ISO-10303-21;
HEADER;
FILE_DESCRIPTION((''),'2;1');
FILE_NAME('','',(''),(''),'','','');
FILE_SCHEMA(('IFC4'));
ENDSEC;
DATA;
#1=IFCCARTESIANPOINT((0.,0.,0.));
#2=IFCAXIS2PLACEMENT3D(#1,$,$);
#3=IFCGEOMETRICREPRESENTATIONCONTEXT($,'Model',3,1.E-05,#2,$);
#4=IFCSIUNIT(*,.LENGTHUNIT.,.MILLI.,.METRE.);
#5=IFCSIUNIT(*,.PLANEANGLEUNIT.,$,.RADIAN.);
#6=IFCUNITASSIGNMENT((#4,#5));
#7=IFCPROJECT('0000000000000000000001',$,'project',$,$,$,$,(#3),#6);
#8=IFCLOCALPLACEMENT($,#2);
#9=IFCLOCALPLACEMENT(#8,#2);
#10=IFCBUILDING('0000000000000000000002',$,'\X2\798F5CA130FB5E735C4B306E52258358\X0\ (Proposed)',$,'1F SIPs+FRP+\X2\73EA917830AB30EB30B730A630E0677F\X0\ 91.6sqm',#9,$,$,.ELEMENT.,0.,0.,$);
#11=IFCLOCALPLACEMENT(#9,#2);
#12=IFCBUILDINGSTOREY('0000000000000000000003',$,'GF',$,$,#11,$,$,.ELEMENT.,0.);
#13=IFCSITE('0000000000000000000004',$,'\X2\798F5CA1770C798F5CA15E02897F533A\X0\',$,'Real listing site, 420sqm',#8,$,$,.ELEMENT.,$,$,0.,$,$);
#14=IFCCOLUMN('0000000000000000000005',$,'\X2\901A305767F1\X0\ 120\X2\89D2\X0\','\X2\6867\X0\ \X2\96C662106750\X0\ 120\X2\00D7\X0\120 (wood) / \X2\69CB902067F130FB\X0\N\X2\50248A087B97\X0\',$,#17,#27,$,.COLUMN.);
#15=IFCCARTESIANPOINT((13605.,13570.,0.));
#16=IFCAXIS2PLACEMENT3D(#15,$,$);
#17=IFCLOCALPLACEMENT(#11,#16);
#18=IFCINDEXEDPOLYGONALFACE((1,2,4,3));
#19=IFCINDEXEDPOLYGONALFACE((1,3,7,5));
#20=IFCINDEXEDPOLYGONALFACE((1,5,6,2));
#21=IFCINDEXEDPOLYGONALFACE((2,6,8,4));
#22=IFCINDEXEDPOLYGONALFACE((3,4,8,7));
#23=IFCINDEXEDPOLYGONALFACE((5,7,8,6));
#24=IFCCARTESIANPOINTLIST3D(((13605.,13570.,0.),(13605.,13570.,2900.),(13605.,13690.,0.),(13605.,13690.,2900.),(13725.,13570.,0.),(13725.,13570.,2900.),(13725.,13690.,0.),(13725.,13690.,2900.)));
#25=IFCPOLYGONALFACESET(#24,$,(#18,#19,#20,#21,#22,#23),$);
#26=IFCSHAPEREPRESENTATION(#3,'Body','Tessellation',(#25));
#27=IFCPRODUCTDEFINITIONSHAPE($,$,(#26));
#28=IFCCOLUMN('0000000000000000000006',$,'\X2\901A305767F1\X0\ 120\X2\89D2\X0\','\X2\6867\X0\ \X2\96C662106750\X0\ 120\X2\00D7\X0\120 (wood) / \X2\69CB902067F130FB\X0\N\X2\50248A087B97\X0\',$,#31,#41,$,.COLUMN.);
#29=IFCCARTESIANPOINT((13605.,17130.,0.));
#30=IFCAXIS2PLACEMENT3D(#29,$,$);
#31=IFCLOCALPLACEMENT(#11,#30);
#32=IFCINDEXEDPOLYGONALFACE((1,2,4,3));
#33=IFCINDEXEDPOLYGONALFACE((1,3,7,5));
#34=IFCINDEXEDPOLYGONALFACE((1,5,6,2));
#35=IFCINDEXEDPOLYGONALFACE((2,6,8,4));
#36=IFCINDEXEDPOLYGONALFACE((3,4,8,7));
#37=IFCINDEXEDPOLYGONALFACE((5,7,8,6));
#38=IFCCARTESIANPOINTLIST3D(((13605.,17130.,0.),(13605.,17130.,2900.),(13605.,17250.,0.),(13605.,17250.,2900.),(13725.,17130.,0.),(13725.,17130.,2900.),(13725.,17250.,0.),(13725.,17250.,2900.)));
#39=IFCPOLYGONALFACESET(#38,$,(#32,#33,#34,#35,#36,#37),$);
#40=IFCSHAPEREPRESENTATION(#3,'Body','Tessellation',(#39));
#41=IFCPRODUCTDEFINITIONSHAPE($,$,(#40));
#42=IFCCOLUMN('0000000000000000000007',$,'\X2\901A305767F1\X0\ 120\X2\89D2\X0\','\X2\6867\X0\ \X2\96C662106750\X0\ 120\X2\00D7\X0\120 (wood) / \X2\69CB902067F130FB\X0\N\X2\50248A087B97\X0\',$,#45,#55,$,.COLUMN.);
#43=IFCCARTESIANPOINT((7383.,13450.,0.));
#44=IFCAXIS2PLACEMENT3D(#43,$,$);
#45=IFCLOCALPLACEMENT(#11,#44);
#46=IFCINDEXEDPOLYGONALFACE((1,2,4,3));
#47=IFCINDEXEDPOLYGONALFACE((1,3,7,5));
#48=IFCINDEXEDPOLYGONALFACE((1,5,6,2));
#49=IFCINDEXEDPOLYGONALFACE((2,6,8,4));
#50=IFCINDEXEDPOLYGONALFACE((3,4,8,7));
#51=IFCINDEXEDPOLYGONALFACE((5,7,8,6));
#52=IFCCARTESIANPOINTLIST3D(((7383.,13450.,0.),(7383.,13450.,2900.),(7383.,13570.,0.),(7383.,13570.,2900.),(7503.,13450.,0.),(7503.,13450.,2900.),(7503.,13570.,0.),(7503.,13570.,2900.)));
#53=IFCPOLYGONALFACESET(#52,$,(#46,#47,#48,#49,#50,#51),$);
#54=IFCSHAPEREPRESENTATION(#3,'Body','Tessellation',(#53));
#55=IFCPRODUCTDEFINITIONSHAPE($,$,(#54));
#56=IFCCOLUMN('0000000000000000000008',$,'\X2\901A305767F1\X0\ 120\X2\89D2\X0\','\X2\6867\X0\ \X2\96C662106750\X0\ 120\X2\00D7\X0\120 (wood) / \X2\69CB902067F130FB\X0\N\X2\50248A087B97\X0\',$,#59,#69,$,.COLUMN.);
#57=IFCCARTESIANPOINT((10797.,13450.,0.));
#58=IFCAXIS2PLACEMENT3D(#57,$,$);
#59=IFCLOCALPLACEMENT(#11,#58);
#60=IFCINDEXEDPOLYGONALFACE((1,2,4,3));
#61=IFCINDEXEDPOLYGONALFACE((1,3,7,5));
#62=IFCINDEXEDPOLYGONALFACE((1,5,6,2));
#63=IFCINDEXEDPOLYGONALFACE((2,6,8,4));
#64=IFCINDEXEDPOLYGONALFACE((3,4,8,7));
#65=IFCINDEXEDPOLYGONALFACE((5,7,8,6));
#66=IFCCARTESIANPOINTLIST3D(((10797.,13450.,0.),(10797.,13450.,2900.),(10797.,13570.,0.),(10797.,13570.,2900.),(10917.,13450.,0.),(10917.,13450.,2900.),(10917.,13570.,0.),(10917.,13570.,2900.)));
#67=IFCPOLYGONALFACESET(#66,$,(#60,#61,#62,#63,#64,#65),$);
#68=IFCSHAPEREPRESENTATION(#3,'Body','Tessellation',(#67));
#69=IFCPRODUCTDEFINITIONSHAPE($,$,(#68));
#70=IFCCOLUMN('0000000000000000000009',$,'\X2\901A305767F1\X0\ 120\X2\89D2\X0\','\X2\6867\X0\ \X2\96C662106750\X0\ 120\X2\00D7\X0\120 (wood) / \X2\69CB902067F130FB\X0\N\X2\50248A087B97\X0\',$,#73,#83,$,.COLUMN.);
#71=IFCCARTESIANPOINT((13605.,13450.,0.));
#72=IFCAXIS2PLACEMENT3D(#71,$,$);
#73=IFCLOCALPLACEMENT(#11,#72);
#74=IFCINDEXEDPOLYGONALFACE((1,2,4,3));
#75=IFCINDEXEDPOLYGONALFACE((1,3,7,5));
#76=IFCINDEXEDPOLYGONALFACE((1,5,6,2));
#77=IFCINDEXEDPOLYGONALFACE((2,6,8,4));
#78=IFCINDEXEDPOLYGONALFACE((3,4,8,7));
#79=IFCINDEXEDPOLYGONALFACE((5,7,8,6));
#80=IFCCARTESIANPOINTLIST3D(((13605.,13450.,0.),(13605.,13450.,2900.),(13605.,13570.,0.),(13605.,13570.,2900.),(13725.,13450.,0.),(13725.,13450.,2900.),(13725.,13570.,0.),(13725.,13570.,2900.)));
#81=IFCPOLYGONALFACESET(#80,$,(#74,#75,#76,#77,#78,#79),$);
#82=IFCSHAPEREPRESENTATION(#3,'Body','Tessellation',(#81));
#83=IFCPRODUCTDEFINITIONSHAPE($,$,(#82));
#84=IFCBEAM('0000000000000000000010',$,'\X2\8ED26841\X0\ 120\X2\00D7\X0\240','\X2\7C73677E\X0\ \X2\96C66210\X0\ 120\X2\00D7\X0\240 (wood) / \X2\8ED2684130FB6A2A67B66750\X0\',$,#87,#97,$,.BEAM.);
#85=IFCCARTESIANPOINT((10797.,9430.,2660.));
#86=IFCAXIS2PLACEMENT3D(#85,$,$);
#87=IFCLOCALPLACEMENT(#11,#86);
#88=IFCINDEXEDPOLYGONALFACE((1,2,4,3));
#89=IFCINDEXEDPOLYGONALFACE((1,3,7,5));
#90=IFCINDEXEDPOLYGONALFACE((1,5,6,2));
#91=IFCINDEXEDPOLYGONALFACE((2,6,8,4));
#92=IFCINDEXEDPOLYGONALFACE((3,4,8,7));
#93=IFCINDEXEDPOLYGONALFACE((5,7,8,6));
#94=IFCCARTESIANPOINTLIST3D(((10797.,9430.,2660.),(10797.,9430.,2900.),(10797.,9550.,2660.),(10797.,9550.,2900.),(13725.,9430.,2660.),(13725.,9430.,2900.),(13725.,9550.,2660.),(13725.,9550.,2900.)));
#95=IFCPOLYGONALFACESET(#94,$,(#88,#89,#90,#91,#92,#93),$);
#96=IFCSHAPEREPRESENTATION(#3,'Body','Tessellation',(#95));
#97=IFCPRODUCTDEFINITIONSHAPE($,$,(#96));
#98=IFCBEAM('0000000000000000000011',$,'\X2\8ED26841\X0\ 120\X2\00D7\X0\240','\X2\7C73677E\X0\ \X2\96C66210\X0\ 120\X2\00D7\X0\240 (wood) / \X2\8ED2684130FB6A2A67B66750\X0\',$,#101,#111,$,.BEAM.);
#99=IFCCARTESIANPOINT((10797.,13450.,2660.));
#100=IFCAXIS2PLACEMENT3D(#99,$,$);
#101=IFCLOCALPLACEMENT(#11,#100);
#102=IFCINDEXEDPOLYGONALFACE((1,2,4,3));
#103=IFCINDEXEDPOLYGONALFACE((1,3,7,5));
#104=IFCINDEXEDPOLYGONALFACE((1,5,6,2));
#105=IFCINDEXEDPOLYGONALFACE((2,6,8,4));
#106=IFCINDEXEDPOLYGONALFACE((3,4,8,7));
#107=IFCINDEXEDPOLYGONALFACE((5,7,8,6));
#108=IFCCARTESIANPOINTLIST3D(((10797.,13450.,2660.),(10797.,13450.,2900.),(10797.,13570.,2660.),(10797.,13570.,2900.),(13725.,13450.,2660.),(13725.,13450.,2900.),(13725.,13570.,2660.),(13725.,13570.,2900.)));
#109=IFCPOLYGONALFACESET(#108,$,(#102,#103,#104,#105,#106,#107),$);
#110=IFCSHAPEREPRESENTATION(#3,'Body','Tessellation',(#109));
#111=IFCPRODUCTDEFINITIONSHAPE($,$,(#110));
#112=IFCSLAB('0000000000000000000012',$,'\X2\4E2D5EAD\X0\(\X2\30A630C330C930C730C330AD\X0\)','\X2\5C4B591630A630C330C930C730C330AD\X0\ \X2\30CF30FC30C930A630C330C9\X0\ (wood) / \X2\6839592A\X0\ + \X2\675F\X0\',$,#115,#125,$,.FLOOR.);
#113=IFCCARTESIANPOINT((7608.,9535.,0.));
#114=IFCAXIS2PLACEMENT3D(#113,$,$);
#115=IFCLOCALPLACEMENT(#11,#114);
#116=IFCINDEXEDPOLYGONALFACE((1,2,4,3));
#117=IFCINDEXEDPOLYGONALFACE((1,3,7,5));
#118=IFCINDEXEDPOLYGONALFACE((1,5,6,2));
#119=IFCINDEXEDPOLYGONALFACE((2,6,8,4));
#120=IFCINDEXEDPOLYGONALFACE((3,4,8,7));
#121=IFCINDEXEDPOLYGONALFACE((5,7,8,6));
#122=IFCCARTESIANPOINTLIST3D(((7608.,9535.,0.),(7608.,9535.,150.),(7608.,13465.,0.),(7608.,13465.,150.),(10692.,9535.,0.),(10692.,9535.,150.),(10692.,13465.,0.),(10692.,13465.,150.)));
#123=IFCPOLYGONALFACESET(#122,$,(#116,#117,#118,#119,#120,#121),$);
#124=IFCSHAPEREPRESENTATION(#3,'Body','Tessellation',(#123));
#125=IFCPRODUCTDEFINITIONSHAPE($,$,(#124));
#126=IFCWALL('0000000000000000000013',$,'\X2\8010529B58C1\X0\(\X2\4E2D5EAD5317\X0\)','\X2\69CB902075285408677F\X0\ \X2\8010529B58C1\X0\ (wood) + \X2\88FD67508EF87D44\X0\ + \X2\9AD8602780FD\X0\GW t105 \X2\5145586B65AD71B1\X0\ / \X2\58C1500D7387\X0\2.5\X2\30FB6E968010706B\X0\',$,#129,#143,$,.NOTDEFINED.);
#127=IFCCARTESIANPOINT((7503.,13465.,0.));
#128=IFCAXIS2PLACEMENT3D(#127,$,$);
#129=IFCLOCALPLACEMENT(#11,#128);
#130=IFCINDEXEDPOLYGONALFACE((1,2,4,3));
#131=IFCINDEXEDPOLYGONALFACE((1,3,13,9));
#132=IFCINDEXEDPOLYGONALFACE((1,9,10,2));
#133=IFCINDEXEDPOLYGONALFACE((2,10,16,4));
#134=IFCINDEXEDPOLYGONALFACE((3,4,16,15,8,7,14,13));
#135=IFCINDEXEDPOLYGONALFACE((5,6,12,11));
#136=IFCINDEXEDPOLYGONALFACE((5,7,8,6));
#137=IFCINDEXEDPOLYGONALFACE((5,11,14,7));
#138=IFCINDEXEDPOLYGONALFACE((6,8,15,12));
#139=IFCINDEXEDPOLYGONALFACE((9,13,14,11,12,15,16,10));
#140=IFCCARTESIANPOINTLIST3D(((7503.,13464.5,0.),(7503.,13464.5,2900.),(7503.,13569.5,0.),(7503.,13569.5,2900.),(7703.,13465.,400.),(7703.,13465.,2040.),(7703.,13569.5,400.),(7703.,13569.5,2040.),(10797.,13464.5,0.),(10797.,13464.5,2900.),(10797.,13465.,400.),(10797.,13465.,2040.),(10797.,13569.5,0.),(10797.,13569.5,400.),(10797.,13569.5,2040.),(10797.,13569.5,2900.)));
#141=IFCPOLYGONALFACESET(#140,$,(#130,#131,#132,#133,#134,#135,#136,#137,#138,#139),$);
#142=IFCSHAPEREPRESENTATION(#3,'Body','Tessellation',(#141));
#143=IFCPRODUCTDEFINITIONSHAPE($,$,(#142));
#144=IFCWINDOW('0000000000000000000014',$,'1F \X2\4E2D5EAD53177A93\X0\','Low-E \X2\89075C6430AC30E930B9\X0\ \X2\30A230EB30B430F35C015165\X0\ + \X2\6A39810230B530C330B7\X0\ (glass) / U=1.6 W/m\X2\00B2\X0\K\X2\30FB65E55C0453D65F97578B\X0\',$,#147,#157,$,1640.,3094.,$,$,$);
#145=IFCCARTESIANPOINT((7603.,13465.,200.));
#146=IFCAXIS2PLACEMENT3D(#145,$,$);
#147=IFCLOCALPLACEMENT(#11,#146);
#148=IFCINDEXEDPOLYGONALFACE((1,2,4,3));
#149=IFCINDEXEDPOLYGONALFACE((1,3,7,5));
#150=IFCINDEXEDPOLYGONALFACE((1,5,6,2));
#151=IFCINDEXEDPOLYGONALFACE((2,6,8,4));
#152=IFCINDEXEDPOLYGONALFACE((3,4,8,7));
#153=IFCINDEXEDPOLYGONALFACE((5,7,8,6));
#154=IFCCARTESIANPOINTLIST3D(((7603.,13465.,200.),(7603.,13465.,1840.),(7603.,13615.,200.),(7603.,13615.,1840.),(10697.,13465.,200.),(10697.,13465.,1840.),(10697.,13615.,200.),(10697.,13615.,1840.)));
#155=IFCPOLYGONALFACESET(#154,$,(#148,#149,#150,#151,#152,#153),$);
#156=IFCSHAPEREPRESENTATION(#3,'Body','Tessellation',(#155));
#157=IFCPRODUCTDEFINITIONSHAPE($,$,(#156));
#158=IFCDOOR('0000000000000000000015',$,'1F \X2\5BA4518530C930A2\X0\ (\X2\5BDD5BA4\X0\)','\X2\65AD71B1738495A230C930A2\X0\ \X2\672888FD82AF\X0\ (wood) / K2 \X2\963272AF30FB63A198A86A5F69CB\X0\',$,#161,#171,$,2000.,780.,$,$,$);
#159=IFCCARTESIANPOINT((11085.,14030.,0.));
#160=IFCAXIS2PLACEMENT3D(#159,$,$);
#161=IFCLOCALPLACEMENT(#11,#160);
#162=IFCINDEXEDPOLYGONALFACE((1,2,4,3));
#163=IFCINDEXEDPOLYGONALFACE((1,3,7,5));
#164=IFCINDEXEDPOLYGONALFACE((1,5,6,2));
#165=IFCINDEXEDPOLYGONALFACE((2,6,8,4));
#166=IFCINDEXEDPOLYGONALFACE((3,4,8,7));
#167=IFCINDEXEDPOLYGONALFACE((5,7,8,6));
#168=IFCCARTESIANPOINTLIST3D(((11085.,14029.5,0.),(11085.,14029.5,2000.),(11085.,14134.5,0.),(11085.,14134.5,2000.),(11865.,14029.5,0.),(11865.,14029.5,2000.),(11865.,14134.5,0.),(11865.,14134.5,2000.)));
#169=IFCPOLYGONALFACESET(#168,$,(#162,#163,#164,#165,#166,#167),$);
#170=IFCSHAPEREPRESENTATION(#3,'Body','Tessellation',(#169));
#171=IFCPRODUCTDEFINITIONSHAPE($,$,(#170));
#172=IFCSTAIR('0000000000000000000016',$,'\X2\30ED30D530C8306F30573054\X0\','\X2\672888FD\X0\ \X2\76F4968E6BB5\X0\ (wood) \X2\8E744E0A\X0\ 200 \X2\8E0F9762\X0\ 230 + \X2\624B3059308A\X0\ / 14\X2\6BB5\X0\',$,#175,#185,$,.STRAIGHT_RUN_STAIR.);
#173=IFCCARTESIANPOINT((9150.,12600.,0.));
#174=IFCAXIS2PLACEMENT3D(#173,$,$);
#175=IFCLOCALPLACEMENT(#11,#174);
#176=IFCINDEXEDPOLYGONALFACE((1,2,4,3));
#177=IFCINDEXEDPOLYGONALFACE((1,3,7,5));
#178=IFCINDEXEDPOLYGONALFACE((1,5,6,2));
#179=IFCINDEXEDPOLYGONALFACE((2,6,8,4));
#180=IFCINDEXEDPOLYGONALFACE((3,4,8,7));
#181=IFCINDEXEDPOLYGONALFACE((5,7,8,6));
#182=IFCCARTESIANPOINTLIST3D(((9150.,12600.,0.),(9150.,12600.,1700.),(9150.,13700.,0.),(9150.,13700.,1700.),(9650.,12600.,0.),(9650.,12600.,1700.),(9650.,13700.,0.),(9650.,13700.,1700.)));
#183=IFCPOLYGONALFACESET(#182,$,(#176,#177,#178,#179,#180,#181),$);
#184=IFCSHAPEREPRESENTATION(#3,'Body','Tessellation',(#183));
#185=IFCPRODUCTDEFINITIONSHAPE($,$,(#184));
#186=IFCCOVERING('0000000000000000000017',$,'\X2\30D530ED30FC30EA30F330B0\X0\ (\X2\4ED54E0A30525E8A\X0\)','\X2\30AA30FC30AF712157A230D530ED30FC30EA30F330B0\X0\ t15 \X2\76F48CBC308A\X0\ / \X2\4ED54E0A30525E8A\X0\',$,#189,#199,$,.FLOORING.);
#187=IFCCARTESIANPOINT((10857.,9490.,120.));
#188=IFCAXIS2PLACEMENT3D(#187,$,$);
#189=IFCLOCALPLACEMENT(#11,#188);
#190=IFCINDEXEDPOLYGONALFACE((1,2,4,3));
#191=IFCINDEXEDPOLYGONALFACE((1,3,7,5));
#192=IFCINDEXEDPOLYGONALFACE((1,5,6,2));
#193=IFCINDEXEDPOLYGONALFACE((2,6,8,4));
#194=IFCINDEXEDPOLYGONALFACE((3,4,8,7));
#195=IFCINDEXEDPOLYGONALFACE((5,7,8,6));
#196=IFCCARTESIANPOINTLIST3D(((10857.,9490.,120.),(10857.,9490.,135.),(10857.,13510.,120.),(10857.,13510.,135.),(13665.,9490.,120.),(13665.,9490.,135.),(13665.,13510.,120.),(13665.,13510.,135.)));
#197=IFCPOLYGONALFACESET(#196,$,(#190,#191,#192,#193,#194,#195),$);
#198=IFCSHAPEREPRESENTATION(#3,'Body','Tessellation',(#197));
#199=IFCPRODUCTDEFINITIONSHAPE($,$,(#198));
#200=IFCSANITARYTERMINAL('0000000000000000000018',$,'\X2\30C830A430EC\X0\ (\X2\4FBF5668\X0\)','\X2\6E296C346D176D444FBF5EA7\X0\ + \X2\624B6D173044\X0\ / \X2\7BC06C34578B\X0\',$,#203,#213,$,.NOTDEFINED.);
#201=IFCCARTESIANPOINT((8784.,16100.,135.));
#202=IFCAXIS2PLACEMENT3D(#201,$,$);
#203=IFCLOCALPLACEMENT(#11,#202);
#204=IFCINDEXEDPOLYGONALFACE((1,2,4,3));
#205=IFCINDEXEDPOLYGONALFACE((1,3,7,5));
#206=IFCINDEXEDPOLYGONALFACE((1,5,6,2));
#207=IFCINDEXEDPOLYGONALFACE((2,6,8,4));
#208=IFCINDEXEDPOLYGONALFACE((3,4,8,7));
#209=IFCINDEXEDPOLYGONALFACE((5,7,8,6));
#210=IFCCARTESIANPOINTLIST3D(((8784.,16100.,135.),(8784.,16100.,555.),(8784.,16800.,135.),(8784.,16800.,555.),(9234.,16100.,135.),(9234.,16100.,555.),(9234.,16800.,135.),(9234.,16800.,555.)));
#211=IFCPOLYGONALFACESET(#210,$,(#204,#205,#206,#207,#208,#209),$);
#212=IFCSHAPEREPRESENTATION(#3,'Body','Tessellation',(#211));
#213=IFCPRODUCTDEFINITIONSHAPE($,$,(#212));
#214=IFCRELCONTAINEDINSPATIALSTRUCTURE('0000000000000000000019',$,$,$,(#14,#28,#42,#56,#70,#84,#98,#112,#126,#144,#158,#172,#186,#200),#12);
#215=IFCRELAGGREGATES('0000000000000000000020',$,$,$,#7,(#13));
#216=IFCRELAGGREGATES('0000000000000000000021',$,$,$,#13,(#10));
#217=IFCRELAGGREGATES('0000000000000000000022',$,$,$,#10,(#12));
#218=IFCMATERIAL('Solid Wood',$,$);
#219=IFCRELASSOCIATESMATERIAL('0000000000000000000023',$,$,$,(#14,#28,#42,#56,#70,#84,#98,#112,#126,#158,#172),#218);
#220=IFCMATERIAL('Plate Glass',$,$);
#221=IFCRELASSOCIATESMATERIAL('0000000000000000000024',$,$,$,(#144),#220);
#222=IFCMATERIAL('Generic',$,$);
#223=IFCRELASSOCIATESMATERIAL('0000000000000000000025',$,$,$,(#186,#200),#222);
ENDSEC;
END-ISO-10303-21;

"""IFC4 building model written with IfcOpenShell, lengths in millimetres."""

from ifc_helpers import new_model, si_unit, frame, frame_2d, origin, place, context, project, spatial, rectangle, extrude, material, element, fill, save


model = new_model("IFC4")

# Units and contexts
model_context = context("Model", 3, precision=1e-05, world=origin())
ifc_project = project(units=[si_unit("LENGTHUNIT", "METRE", prefix="MILLI"), si_unit("PLANEANGLEUNIT", "RADIAN")], contexts=[model_context])

# Site, building, storey
site_placement = place(None, origin())
site = spatial("IfcSite", under=ifc_project, at=site_placement, Name="福岡県福岡市西区", ObjectType="Real listing site, 420sqm", CompositionType="ELEMENT", RefElevation=0.0)
building_placement = place(site_placement, origin())
building = spatial("IfcBuilding", under=site, at=building_placement, Name="福岡・平屋の別荘 (Proposed)", ObjectType="1F SIPs+FRP+珪酸カルシウム板 91.6sqm", CompositionType="ELEMENT", ElevationOfRefHeight=0.0, ElevationOfTerrain=0.0)
storey_placement = place(building_placement, origin())
storey = spatial("IfcBuildingStorey", under=building, at=storey_placement, Name="GF", CompositionType="ELEMENT", Elevation=0.0)

# Columns
ifc_material_1 = material(Name="Solid Wood")
column_1_placement = place(storey_placement, frame((13605.0, 13570.0, 0.0)))
element("IfcColumn", 1, at=column_1_placement, inside=storey, material=ifc_material_1, Name="通し柱 120角", Description="桧 集成材 120×120 (wood) / 構造柱・N値計算", PredefinedType="COLUMN", context=model_context, shape_type="SweptSolid", body=[
    extrude(rectangle(XDim=120.0, YDim=120.0, at=frame_2d((60.0, 60.0))), frame((13605.0, 13570.0, 0.0)), (0.0, 0.0, 1.0), 2900.0),
])
column_2_placement = place(storey_placement, frame((13605.0, 17130.0, 0.0)))
element("IfcColumn", 2, at=column_2_placement, inside=storey, material=ifc_material_1, Name="通し柱 120角", Description="桧 集成材 120×120 (wood) / 構造柱・N値計算", PredefinedType="COLUMN", context=model_context, shape_type="SweptSolid", body=[
    extrude(rectangle(XDim=120.0, YDim=120.0, at=frame_2d((60.0, 60.0))), frame((13605.0, 17130.0, 0.0)), (0.0, 0.0, 1.0), 2900.0),
])
column_3_placement = place(storey_placement, frame((7383.0, 13450.0, 0.0)))
element("IfcColumn", 3, at=column_3_placement, inside=storey, material=ifc_material_1, Name="通し柱 120角", Description="桧 集成材 120×120 (wood) / 構造柱・N値計算", PredefinedType="COLUMN", context=model_context, shape_type="SweptSolid", body=[
    extrude(rectangle(XDim=120.0, YDim=120.0, at=frame_2d((60.0, 60.0))), frame((7383.0, 13450.0, 0.0)), (0.0, 0.0, 1.0), 2900.0),
])
column_4_placement = place(storey_placement, frame((10797.0, 13450.0, 0.0)))
element("IfcColumn", 4, at=column_4_placement, inside=storey, material=ifc_material_1, Name="通し柱 120角", Description="桧 集成材 120×120 (wood) / 構造柱・N値計算", PredefinedType="COLUMN", context=model_context, shape_type="SweptSolid", body=[
    extrude(rectangle(XDim=120.0, YDim=120.0, at=frame_2d((60.0, 60.0))), frame((10797.0, 13450.0, 0.0)), (0.0, 0.0, 1.0), 2900.0),
])
column_5_placement = place(storey_placement, frame((13605.0, 13450.0, 0.0)))
element("IfcColumn", 5, at=column_5_placement, inside=storey, material=ifc_material_1, Name="通し柱 120角", Description="桧 集成材 120×120 (wood) / 構造柱・N値計算", PredefinedType="COLUMN", context=model_context, shape_type="SweptSolid", body=[
    extrude(rectangle(XDim=120.0, YDim=120.0, at=frame_2d((60.0, 60.0))), frame((13605.0, 13450.0, 0.0)), (0.0, 0.0, 1.0), 2900.0),
])

# Beams
beam_1_placement = place(storey_placement, frame((10797.0, 9430.0, 2660.0)))
element("IfcBeam", 6, at=beam_1_placement, inside=storey, material=ifc_material_1, Name="軒桁 120×240", Description="米松 集成 120×240 (wood) / 軒桁・横架材", PredefinedType="BEAM", context=model_context, shape_type="SweptSolid", body=[
    extrude(rectangle(XDim=2928.0, YDim=120.0, at=frame_2d((1464.0, 60.0))), frame((10797.0, 9430.0, 2660.0)), (0.0, 0.0, 1.0), 240.0),
])
beam_2_placement = place(storey_placement, frame((10797.0, 13450.0, 2660.0)))
element("IfcBeam", 7, at=beam_2_placement, inside=storey, material=ifc_material_1, Name="軒桁 120×240", Description="米松 集成 120×240 (wood) / 軒桁・横架材", PredefinedType="BEAM", context=model_context, shape_type="SweptSolid", body=[
    extrude(rectangle(XDim=2928.0, YDim=120.0, at=frame_2d((1464.0, 60.0))), frame((10797.0, 13450.0, 2660.0)), (0.0, 0.0, 1.0), 240.0),
])

# Slab
slab_placement = place(storey_placement, frame((7608.0, 9535.0, 0.0)))
element("IfcSlab", 8, at=slab_placement, inside=storey, material=ifc_material_1, Name="中庭(ウッドデッキ)", Description="屋外ウッドデッキ ハードウッド (wood) / 根太 + 束", PredefinedType="FLOOR", context=model_context, shape_type="SweptSolid", body=[
    extrude(rectangle(XDim=3084.0, YDim=3930.0, at=frame_2d((1542.0, 1965.0))), frame((7608.0, 9535.0, 0.0)), (0.0, 0.0, 1.0), 150.0),
])

# Wall, opening, window
wall_1_placement = place(storey_placement, frame((7503.0, 13465.0, 0.0)))
wall_1 = element("IfcWall", 9, at=wall_1_placement, inside=storey, material=ifc_material_1, Name="耐力壁(中庭北)", Description="構造用合板 耐力壁 (wood) + 製材軸組 + 高性能GW t105 充填断熱 / 壁倍率2.5・準耐火", PredefinedType="NOTDEFINED", context=model_context, shape_type="SweptSolid", body=[
    extrude(rectangle(XDim=3294.0, YDim=105.0, at=frame_2d((1647.0, 52.0))), frame((7503.0, 13465.0, 0.0)), (0.0, 0.0, 1.0), 2900.0),
])
opening_placement = place(storey_placement, frame((7603.0, 13465.0, 200.0)))
opening = element("IfcOpeningElement", 10, at=opening_placement, cuts=wall_1, PredefinedType="NOTDEFINED", context=model_context, shape_type="SweptSolid", body=[
    extrude(rectangle(XDim=3094.0, YDim=150.0, at=frame_2d((1547.0, 75.0))), frame((7603.0, 13465.0, 200.0)), (0.0, 0.0, 1.0), 1640.0),
])
ifc_material_2 = material(Name="Plate Glass")
window_placement = place(storey_placement, frame((7603.0, 13465.0, 200.0)))
window = element("IfcWindow", 11, at=window_placement, inside=storey, material=ifc_material_2, Name="1F 中庭北窓", Description="Low-E 複層ガラス アルゴン封入 + 樹脂サッシ (glass) / U=1.6 W/m²K・日射取得型", OverallHeight=1640.0, OverallWidth=3094.0, context=model_context, shape_type="SweptSolid", body=[
    extrude(rectangle(XDim=3094.0, YDim=150.0, at=frame_2d((1547.0, 75.0))), frame((7603.0, 13465.0, 200.0)), (0.0, 0.0, 1.0), 1640.0),
])
fill(opening, window)

# Door
door_placement = place(storey_placement, frame((11085.0, 14030.0, 0.0)))
element("IfcDoor", 12, at=door_placement, inside=storey, material=ifc_material_1, Name="1F 室内ドア (寝室)", Description="断熱玄関ドア 木製芯 (wood) / K2 防犯・採風機構", OverallHeight=2000.0, OverallWidth=780.0, context=model_context, shape_type="SweptSolid", body=[
    extrude(rectangle(XDim=780.0, YDim=105.0, at=frame_2d((390.0, 52.0))), frame((11085.0, 14030.0, 0.0)), (0.0, 0.0, 1.0), 2000.0),
])

# Stair
stair_placement = place(storey_placement, frame((9150.0, 12600.0, 0.0)))
element("IfcStair", 13, at=stair_placement, inside=storey, material=ifc_material_1, Name="ロフトはしご", Description="木製 直階段 (wood) 蹴上 200 踏面 230 + 手すり / 14段", PredefinedType="STRAIGHT_RUN_STAIR", context=model_context, shape_type="SweptSolid", body=[
    extrude(rectangle(XDim=500.0, YDim=1100.0, at=frame_2d((250.0, 550.0))), frame((9150.0, 12600.0, 0.0)), (0.0, 0.0, 1.0), 1700.0),
])

# Covering
ifc_material_3 = material(Name="Generic")
covering_placement = place(storey_placement, frame((10857.0, 9490.0, 120.0)))
element("IfcCovering", 14, at=covering_placement, inside=storey, material=ifc_material_3, Name="フローリング (仕上げ床)", Description="オーク無垢フローリング t15 直貼り / 仕上げ床", PredefinedType="FLOORING", context=model_context, shape_type="SweptSolid", body=[
    extrude(rectangle(XDim=2808.0, YDim=4020.0, at=frame_2d((1404.0, 2010.0))), frame((10857.0, 9490.0, 120.0)), (0.0, 0.0, 1.0), 15.0),
])

# Sanitary terminal
sanitary_terminal_placement = place(storey_placement, frame((8784.0, 16100.0, 135.0)))
element("IfcSanitaryTerminal", 15, at=sanitary_terminal_placement, inside=storey, material=ifc_material_3, Name="トイレ (便器)", Description="温水洗浄便座 + 手洗い / 節水型", PredefinedType="NOTDEFINED", context=model_context, shape_type="SweptSolid", body=[
    extrude(rectangle(XDim=450.0, YDim=700.0, at=frame_2d((225.0, 350.0))), frame((8784.0, 16100.0, 135.0)), (0.0, 0.0, 1.0), 420.0),
])

save(model, "model.ifc")
